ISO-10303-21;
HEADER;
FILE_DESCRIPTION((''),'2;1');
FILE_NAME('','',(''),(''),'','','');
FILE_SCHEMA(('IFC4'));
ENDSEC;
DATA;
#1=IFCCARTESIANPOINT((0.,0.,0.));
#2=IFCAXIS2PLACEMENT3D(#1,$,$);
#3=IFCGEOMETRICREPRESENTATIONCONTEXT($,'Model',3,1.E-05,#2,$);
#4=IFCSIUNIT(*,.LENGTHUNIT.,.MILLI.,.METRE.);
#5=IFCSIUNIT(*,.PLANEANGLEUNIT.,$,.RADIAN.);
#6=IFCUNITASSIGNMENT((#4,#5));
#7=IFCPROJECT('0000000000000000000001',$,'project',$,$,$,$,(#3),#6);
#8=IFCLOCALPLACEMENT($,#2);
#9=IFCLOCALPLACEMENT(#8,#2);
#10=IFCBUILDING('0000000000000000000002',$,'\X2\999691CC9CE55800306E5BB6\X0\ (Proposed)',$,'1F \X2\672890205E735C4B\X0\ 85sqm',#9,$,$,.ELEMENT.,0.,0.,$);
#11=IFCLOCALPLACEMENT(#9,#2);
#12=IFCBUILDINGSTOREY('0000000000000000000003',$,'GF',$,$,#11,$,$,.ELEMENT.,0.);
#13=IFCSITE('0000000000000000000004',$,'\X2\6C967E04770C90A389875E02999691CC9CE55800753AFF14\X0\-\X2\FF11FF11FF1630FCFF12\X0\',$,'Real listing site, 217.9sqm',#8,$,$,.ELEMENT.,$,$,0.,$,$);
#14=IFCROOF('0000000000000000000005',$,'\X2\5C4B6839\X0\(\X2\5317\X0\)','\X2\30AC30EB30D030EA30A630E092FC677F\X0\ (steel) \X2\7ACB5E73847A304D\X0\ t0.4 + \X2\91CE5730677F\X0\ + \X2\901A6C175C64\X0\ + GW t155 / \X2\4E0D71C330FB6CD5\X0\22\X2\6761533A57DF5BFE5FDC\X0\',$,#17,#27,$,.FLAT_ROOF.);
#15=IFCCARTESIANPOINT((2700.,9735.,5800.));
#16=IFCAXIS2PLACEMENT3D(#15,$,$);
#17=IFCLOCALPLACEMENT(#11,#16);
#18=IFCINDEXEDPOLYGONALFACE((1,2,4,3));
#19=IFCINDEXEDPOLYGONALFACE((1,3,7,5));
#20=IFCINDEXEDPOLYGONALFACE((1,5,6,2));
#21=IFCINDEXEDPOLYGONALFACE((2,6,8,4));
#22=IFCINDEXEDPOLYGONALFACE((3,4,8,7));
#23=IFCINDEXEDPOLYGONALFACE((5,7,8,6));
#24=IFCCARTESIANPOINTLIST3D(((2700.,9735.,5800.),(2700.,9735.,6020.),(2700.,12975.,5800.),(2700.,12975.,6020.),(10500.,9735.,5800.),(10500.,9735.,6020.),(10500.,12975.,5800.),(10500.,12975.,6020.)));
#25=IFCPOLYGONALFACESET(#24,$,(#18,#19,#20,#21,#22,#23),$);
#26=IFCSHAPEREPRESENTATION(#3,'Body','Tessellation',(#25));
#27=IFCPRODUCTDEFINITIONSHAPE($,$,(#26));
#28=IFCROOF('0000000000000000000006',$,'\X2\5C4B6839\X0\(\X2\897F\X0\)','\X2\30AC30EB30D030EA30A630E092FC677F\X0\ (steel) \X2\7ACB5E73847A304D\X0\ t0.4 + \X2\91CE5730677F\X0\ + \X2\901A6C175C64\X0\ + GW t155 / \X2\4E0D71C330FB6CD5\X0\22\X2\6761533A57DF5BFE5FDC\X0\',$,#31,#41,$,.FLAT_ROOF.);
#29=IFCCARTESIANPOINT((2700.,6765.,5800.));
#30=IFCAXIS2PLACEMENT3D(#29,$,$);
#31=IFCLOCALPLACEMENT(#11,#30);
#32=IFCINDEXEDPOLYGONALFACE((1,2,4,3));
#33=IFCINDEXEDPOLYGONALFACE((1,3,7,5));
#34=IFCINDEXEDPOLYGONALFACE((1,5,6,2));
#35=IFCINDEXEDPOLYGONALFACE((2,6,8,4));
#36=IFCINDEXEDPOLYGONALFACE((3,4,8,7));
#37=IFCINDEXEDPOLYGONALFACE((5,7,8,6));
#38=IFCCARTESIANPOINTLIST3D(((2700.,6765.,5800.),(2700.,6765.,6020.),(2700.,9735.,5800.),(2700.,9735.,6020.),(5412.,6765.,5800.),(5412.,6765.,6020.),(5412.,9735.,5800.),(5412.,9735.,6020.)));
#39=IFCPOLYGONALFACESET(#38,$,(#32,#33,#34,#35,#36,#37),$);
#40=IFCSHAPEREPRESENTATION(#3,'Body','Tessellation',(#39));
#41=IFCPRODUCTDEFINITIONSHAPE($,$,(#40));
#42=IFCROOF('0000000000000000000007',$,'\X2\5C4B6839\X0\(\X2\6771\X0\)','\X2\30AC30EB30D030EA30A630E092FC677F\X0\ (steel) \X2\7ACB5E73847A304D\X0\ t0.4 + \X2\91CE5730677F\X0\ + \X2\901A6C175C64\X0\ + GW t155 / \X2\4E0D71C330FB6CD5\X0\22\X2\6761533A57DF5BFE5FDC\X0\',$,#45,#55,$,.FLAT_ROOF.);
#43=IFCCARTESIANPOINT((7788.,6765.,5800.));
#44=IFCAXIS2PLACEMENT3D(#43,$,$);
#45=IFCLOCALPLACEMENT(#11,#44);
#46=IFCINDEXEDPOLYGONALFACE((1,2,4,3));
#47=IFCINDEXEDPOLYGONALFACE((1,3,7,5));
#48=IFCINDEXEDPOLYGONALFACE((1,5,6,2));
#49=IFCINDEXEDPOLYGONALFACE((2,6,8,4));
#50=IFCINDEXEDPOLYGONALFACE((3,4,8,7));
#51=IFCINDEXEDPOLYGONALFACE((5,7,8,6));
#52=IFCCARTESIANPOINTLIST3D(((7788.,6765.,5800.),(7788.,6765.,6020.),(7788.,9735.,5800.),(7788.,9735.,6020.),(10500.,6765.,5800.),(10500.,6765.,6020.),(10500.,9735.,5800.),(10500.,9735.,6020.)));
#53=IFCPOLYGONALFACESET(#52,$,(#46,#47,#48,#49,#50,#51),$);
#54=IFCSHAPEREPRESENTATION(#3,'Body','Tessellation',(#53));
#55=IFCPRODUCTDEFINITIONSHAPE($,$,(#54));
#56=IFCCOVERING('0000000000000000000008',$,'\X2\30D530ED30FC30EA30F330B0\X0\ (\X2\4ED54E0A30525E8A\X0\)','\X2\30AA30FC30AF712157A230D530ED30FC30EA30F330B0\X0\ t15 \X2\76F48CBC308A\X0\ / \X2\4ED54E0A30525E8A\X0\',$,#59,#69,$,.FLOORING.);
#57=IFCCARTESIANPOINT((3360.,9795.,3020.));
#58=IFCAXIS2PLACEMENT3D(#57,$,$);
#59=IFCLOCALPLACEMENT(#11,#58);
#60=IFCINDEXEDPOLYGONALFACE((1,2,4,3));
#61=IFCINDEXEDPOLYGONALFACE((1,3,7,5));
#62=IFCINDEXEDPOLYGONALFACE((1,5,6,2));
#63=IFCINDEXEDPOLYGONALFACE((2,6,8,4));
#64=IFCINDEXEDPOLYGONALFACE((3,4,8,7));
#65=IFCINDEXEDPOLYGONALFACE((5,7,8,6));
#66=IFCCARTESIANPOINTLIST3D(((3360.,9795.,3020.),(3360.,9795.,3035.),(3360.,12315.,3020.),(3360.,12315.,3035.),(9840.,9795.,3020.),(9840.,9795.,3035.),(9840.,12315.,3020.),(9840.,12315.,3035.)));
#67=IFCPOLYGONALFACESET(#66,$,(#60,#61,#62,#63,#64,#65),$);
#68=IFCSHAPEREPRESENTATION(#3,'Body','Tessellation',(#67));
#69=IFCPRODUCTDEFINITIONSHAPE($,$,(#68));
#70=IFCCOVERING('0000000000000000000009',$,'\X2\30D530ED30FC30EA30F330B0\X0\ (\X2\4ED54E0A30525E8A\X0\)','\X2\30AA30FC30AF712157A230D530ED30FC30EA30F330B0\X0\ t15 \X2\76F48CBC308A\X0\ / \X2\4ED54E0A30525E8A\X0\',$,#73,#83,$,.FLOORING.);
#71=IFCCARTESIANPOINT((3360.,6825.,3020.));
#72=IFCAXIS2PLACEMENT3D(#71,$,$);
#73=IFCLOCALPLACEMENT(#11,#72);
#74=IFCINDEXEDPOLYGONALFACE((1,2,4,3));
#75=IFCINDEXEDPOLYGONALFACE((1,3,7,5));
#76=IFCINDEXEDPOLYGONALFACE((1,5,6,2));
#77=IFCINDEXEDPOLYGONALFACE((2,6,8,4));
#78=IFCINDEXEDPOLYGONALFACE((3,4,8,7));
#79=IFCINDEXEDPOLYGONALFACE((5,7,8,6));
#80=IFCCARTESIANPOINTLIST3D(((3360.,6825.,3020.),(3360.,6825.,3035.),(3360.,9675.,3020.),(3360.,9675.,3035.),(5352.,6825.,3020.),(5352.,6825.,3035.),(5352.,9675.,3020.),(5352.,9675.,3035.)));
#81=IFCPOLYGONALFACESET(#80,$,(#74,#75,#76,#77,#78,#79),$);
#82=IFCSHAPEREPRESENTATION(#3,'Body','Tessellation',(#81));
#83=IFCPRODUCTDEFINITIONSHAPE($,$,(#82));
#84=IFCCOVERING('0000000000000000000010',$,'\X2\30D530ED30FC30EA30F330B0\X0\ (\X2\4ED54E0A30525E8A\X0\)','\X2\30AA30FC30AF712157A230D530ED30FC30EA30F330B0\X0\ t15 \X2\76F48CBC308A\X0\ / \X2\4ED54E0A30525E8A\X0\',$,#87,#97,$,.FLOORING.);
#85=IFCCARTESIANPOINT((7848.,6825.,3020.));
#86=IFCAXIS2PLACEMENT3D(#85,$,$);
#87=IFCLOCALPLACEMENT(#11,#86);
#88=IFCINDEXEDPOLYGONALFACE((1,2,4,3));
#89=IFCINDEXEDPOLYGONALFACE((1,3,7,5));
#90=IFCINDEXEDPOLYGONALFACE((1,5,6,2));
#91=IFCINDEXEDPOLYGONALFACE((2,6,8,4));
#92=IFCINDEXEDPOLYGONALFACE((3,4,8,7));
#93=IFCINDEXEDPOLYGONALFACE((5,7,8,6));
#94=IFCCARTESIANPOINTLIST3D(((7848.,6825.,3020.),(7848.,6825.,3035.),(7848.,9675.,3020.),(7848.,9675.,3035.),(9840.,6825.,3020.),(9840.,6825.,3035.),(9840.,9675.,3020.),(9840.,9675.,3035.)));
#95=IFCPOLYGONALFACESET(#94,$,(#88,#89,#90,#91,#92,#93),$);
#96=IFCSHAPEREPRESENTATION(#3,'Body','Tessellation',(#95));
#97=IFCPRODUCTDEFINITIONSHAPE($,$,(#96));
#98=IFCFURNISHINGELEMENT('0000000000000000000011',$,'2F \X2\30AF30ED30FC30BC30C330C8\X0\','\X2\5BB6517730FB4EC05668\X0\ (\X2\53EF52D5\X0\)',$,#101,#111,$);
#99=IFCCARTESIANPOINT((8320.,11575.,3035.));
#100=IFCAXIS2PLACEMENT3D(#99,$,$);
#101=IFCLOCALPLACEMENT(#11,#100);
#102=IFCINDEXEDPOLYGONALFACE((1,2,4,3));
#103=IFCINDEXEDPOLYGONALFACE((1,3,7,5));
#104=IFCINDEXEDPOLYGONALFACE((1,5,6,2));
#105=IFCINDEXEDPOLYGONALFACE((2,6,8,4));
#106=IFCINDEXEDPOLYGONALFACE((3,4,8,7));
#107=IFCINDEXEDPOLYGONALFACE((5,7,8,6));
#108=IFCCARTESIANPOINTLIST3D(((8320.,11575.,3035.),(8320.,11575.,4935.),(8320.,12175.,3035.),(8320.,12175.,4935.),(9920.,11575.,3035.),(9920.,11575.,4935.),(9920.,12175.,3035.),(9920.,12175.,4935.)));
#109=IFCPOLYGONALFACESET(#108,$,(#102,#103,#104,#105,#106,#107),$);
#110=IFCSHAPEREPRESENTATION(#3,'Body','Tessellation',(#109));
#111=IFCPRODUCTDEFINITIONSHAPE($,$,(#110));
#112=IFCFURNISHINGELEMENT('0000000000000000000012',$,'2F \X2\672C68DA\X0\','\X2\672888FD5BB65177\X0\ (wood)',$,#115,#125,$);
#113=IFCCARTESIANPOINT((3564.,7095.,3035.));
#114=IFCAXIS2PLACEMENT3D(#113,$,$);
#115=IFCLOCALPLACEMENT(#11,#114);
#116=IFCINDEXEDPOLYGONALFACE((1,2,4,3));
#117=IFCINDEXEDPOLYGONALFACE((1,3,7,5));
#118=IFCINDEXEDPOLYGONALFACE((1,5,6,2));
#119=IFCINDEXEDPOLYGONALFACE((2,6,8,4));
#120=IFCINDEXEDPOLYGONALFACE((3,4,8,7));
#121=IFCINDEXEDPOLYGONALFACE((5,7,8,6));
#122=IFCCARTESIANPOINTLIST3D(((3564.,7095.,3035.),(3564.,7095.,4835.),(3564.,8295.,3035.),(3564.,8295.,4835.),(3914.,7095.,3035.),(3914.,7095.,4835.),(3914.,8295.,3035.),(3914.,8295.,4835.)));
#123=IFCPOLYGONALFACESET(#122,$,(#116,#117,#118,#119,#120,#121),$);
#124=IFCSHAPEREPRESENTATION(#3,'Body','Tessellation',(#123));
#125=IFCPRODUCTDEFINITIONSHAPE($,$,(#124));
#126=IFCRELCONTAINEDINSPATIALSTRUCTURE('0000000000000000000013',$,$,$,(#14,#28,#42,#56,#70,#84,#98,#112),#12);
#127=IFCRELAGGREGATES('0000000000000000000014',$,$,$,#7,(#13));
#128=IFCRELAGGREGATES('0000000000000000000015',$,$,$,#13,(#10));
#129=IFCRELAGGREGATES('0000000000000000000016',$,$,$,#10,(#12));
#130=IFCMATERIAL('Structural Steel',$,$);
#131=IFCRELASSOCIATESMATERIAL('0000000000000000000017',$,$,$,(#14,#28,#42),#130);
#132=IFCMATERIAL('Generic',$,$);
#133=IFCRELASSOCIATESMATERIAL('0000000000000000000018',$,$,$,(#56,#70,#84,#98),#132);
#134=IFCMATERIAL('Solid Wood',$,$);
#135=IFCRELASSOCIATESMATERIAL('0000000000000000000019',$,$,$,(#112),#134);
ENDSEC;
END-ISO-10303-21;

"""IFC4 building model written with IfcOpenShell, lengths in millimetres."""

from ifc_helpers import new_model, si_unit, frame, frame_2d, origin, place, context, project, spatial, rectangle, extrude, material, element, save


model = new_model("IFC4")

# Units and contexts
model_context = context("Model", 3, precision=1e-05, world=origin())
ifc_project = project(units=[si_unit("LENGTHUNIT", "METRE", prefix="MILLI"), si_unit("PLANEANGLEUNIT", "RADIAN")], contexts=[model_context])

# Site, building, storey
site_placement = place(None, origin())
site = spatial("IfcSite", under=ifc_project, at=site_placement, Name="沖縄県那覇市首里鳥堀町４-１１６ー２", ObjectType="Real listing site, 217.9sqm", CompositionType="ELEMENT", RefElevation=0.0)
building_placement = place(site_placement, origin())
building = spatial("IfcBuilding", under=site, at=building_placement, Name="首里鳥堀の家 (Proposed)", ObjectType="1F 木造平屋 85sqm", CompositionType="ELEMENT", ElevationOfRefHeight=0.0, ElevationOfTerrain=0.0)
storey_placement = place(building_placement, origin())
storey = spatial("IfcBuildingStorey", under=building, at=storey_placement, Name="GF", CompositionType="ELEMENT", Elevation=0.0)

# Shared definitions
ifc_material_1 = material(Name="Solid Wood")

# Shared definitions
ifc_material_2 = material(Name="Generic")

# Roofs
ifc_material_3 = material(Name="Structural Steel")
for number, where, name in (
    (1, (2700.0, 9735.0, 5800.0), "屋根(北)"),
):
    element("IfcRoof", number, at=place(storey_placement, frame(where)), inside=storey, material=ifc_material_3, Name=name, Description="ガルバリウム鋼板 (steel) 立平葺き t0.4 + 野地板 + 通気層 + GW t155 / 不燃・法22条区域対応", PredefinedType="FLAT_ROOF", context=model_context, shape_type="SweptSolid", body=[
        extrude(rectangle(XDim=7800.0, YDim=3240.0, at=frame_2d((3900.0, 1620.0))), frame((2700.0, 9735.0, 5800.0)), (0.0, 0.0, 1.0), 220.0),
    ])
roof_1_placement = place(storey_placement, frame((2700.0, 6765.0, 5800.0)))
element("IfcRoof", 2, at=roof_1_placement, inside=storey, material=ifc_material_3, Name="屋根(西)", Description="ガルバリウム鋼板 (steel) 立平葺き t0.4 + 野地板 + 通気層 + GW t155 / 不燃・法22条区域対応", PredefinedType="FLAT_ROOF", context=model_context, shape_type="SweptSolid", body=[
    extrude(rectangle(XDim=2712.0, YDim=2970.0, at=frame_2d((1356.0, 1485.0))), frame((2700.0, 6765.0, 5800.0)), (0.0, 0.0, 1.0), 220.0),
])
roof_2_placement = place(storey_placement, frame((7788.0, 6765.0, 5800.0)))
element("IfcRoof", 3, at=roof_2_placement, inside=storey, material=ifc_material_3, Name="屋根(東)", Description="ガルバリウム鋼板 (steel) 立平葺き t0.4 + 野地板 + 通気層 + GW t155 / 不燃・法22条区域対応", PredefinedType="FLAT_ROOF", context=model_context, shape_type="SweptSolid", body=[
    extrude(rectangle(XDim=2712.0, YDim=2970.0, at=frame_2d((1356.0, 1485.0))), frame((7788.0, 6765.0, 5800.0)), (0.0, 0.0, 1.0), 220.0),
])

# Coverings
covering_1_placement = place(storey_placement, frame((3360.0, 9795.0, 3020.0)))
element("IfcCovering", 4, at=covering_1_placement, inside=storey, material=ifc_material_2, Name="フローリング (仕上げ床)", Description="オーク無垢フローリング t15 直貼り / 仕上げ床", PredefinedType="FLOORING", context=model_context, shape_type="SweptSolid", body=[
    extrude(rectangle(XDim=6480.0, YDim=2520.0, at=frame_2d((3240.0, 1260.0))), frame((3360.0, 9795.0, 3020.0)), (0.0, 0.0, 1.0), 15.0),
])
covering_2_placement = place(storey_placement, frame((3360.0, 6825.0, 3020.0)))
element("IfcCovering", 5, at=covering_2_placement, inside=storey, material=ifc_material_2, Name="フローリング (仕上げ床)", Description="オーク無垢フローリング t15 直貼り / 仕上げ床", PredefinedType="FLOORING", context=model_context, shape_type="SweptSolid", body=[
    extrude(rectangle(XDim=1992.0, YDim=2850.0, at=frame_2d((996.0, 1425.0))), frame((3360.0, 6825.0, 3020.0)), (0.0, 0.0, 1.0), 15.0),
])
covering_3_placement = place(storey_placement, frame((7848.0, 6825.0, 3020.0)))
element("IfcCovering", 6, at=covering_3_placement, inside=storey, material=ifc_material_2, Name="フローリング (仕上げ床)", Description="オーク無垢フローリング t15 直貼り / 仕上げ床", PredefinedType="FLOORING", context=model_context, shape_type="SweptSolid", body=[
    extrude(rectangle(XDim=1992.0, YDim=2850.0, at=frame_2d((996.0, 1425.0))), frame((7848.0, 6825.0, 3020.0)), (0.0, 0.0, 1.0), 15.0),
])

# Furnishing elements
furnishing_1_placement = place(storey_placement, frame((8320.0, 11575.0, 3035.0)))
element("IfcFurnishingElement", 7, at=furnishing_1_placement, inside=storey, material=ifc_material_2, Name="2F クローゼット", Description="家具・什器 (可動)", context=model_context, shape_type="SweptSolid", body=[
    extrude(rectangle(XDim=1600.0, YDim=600.0, at=frame_2d((800.0, 300.0))), frame((8320.0, 11575.0, 3035.0)), (0.0, 0.0, 1.0), 1900.0),
])
furnishing_2_placement = place(storey_placement, frame((3564.0, 7095.0, 3035.0)))
element("IfcFurnishingElement", 8, at=furnishing_2_placement, inside=storey, material=ifc_material_1, Name="2F 本棚", Description="木製家具 (wood)", context=model_context, shape_type="SweptSolid", body=[
    extrude(rectangle(XDim=350.0, YDim=1200.0, at=frame_2d((175.0, 600.0))), frame((3564.0, 7095.0, 3035.0)), (0.0, 0.0, 1.0), 1800.0),
])

save(model, "model.ifc")
